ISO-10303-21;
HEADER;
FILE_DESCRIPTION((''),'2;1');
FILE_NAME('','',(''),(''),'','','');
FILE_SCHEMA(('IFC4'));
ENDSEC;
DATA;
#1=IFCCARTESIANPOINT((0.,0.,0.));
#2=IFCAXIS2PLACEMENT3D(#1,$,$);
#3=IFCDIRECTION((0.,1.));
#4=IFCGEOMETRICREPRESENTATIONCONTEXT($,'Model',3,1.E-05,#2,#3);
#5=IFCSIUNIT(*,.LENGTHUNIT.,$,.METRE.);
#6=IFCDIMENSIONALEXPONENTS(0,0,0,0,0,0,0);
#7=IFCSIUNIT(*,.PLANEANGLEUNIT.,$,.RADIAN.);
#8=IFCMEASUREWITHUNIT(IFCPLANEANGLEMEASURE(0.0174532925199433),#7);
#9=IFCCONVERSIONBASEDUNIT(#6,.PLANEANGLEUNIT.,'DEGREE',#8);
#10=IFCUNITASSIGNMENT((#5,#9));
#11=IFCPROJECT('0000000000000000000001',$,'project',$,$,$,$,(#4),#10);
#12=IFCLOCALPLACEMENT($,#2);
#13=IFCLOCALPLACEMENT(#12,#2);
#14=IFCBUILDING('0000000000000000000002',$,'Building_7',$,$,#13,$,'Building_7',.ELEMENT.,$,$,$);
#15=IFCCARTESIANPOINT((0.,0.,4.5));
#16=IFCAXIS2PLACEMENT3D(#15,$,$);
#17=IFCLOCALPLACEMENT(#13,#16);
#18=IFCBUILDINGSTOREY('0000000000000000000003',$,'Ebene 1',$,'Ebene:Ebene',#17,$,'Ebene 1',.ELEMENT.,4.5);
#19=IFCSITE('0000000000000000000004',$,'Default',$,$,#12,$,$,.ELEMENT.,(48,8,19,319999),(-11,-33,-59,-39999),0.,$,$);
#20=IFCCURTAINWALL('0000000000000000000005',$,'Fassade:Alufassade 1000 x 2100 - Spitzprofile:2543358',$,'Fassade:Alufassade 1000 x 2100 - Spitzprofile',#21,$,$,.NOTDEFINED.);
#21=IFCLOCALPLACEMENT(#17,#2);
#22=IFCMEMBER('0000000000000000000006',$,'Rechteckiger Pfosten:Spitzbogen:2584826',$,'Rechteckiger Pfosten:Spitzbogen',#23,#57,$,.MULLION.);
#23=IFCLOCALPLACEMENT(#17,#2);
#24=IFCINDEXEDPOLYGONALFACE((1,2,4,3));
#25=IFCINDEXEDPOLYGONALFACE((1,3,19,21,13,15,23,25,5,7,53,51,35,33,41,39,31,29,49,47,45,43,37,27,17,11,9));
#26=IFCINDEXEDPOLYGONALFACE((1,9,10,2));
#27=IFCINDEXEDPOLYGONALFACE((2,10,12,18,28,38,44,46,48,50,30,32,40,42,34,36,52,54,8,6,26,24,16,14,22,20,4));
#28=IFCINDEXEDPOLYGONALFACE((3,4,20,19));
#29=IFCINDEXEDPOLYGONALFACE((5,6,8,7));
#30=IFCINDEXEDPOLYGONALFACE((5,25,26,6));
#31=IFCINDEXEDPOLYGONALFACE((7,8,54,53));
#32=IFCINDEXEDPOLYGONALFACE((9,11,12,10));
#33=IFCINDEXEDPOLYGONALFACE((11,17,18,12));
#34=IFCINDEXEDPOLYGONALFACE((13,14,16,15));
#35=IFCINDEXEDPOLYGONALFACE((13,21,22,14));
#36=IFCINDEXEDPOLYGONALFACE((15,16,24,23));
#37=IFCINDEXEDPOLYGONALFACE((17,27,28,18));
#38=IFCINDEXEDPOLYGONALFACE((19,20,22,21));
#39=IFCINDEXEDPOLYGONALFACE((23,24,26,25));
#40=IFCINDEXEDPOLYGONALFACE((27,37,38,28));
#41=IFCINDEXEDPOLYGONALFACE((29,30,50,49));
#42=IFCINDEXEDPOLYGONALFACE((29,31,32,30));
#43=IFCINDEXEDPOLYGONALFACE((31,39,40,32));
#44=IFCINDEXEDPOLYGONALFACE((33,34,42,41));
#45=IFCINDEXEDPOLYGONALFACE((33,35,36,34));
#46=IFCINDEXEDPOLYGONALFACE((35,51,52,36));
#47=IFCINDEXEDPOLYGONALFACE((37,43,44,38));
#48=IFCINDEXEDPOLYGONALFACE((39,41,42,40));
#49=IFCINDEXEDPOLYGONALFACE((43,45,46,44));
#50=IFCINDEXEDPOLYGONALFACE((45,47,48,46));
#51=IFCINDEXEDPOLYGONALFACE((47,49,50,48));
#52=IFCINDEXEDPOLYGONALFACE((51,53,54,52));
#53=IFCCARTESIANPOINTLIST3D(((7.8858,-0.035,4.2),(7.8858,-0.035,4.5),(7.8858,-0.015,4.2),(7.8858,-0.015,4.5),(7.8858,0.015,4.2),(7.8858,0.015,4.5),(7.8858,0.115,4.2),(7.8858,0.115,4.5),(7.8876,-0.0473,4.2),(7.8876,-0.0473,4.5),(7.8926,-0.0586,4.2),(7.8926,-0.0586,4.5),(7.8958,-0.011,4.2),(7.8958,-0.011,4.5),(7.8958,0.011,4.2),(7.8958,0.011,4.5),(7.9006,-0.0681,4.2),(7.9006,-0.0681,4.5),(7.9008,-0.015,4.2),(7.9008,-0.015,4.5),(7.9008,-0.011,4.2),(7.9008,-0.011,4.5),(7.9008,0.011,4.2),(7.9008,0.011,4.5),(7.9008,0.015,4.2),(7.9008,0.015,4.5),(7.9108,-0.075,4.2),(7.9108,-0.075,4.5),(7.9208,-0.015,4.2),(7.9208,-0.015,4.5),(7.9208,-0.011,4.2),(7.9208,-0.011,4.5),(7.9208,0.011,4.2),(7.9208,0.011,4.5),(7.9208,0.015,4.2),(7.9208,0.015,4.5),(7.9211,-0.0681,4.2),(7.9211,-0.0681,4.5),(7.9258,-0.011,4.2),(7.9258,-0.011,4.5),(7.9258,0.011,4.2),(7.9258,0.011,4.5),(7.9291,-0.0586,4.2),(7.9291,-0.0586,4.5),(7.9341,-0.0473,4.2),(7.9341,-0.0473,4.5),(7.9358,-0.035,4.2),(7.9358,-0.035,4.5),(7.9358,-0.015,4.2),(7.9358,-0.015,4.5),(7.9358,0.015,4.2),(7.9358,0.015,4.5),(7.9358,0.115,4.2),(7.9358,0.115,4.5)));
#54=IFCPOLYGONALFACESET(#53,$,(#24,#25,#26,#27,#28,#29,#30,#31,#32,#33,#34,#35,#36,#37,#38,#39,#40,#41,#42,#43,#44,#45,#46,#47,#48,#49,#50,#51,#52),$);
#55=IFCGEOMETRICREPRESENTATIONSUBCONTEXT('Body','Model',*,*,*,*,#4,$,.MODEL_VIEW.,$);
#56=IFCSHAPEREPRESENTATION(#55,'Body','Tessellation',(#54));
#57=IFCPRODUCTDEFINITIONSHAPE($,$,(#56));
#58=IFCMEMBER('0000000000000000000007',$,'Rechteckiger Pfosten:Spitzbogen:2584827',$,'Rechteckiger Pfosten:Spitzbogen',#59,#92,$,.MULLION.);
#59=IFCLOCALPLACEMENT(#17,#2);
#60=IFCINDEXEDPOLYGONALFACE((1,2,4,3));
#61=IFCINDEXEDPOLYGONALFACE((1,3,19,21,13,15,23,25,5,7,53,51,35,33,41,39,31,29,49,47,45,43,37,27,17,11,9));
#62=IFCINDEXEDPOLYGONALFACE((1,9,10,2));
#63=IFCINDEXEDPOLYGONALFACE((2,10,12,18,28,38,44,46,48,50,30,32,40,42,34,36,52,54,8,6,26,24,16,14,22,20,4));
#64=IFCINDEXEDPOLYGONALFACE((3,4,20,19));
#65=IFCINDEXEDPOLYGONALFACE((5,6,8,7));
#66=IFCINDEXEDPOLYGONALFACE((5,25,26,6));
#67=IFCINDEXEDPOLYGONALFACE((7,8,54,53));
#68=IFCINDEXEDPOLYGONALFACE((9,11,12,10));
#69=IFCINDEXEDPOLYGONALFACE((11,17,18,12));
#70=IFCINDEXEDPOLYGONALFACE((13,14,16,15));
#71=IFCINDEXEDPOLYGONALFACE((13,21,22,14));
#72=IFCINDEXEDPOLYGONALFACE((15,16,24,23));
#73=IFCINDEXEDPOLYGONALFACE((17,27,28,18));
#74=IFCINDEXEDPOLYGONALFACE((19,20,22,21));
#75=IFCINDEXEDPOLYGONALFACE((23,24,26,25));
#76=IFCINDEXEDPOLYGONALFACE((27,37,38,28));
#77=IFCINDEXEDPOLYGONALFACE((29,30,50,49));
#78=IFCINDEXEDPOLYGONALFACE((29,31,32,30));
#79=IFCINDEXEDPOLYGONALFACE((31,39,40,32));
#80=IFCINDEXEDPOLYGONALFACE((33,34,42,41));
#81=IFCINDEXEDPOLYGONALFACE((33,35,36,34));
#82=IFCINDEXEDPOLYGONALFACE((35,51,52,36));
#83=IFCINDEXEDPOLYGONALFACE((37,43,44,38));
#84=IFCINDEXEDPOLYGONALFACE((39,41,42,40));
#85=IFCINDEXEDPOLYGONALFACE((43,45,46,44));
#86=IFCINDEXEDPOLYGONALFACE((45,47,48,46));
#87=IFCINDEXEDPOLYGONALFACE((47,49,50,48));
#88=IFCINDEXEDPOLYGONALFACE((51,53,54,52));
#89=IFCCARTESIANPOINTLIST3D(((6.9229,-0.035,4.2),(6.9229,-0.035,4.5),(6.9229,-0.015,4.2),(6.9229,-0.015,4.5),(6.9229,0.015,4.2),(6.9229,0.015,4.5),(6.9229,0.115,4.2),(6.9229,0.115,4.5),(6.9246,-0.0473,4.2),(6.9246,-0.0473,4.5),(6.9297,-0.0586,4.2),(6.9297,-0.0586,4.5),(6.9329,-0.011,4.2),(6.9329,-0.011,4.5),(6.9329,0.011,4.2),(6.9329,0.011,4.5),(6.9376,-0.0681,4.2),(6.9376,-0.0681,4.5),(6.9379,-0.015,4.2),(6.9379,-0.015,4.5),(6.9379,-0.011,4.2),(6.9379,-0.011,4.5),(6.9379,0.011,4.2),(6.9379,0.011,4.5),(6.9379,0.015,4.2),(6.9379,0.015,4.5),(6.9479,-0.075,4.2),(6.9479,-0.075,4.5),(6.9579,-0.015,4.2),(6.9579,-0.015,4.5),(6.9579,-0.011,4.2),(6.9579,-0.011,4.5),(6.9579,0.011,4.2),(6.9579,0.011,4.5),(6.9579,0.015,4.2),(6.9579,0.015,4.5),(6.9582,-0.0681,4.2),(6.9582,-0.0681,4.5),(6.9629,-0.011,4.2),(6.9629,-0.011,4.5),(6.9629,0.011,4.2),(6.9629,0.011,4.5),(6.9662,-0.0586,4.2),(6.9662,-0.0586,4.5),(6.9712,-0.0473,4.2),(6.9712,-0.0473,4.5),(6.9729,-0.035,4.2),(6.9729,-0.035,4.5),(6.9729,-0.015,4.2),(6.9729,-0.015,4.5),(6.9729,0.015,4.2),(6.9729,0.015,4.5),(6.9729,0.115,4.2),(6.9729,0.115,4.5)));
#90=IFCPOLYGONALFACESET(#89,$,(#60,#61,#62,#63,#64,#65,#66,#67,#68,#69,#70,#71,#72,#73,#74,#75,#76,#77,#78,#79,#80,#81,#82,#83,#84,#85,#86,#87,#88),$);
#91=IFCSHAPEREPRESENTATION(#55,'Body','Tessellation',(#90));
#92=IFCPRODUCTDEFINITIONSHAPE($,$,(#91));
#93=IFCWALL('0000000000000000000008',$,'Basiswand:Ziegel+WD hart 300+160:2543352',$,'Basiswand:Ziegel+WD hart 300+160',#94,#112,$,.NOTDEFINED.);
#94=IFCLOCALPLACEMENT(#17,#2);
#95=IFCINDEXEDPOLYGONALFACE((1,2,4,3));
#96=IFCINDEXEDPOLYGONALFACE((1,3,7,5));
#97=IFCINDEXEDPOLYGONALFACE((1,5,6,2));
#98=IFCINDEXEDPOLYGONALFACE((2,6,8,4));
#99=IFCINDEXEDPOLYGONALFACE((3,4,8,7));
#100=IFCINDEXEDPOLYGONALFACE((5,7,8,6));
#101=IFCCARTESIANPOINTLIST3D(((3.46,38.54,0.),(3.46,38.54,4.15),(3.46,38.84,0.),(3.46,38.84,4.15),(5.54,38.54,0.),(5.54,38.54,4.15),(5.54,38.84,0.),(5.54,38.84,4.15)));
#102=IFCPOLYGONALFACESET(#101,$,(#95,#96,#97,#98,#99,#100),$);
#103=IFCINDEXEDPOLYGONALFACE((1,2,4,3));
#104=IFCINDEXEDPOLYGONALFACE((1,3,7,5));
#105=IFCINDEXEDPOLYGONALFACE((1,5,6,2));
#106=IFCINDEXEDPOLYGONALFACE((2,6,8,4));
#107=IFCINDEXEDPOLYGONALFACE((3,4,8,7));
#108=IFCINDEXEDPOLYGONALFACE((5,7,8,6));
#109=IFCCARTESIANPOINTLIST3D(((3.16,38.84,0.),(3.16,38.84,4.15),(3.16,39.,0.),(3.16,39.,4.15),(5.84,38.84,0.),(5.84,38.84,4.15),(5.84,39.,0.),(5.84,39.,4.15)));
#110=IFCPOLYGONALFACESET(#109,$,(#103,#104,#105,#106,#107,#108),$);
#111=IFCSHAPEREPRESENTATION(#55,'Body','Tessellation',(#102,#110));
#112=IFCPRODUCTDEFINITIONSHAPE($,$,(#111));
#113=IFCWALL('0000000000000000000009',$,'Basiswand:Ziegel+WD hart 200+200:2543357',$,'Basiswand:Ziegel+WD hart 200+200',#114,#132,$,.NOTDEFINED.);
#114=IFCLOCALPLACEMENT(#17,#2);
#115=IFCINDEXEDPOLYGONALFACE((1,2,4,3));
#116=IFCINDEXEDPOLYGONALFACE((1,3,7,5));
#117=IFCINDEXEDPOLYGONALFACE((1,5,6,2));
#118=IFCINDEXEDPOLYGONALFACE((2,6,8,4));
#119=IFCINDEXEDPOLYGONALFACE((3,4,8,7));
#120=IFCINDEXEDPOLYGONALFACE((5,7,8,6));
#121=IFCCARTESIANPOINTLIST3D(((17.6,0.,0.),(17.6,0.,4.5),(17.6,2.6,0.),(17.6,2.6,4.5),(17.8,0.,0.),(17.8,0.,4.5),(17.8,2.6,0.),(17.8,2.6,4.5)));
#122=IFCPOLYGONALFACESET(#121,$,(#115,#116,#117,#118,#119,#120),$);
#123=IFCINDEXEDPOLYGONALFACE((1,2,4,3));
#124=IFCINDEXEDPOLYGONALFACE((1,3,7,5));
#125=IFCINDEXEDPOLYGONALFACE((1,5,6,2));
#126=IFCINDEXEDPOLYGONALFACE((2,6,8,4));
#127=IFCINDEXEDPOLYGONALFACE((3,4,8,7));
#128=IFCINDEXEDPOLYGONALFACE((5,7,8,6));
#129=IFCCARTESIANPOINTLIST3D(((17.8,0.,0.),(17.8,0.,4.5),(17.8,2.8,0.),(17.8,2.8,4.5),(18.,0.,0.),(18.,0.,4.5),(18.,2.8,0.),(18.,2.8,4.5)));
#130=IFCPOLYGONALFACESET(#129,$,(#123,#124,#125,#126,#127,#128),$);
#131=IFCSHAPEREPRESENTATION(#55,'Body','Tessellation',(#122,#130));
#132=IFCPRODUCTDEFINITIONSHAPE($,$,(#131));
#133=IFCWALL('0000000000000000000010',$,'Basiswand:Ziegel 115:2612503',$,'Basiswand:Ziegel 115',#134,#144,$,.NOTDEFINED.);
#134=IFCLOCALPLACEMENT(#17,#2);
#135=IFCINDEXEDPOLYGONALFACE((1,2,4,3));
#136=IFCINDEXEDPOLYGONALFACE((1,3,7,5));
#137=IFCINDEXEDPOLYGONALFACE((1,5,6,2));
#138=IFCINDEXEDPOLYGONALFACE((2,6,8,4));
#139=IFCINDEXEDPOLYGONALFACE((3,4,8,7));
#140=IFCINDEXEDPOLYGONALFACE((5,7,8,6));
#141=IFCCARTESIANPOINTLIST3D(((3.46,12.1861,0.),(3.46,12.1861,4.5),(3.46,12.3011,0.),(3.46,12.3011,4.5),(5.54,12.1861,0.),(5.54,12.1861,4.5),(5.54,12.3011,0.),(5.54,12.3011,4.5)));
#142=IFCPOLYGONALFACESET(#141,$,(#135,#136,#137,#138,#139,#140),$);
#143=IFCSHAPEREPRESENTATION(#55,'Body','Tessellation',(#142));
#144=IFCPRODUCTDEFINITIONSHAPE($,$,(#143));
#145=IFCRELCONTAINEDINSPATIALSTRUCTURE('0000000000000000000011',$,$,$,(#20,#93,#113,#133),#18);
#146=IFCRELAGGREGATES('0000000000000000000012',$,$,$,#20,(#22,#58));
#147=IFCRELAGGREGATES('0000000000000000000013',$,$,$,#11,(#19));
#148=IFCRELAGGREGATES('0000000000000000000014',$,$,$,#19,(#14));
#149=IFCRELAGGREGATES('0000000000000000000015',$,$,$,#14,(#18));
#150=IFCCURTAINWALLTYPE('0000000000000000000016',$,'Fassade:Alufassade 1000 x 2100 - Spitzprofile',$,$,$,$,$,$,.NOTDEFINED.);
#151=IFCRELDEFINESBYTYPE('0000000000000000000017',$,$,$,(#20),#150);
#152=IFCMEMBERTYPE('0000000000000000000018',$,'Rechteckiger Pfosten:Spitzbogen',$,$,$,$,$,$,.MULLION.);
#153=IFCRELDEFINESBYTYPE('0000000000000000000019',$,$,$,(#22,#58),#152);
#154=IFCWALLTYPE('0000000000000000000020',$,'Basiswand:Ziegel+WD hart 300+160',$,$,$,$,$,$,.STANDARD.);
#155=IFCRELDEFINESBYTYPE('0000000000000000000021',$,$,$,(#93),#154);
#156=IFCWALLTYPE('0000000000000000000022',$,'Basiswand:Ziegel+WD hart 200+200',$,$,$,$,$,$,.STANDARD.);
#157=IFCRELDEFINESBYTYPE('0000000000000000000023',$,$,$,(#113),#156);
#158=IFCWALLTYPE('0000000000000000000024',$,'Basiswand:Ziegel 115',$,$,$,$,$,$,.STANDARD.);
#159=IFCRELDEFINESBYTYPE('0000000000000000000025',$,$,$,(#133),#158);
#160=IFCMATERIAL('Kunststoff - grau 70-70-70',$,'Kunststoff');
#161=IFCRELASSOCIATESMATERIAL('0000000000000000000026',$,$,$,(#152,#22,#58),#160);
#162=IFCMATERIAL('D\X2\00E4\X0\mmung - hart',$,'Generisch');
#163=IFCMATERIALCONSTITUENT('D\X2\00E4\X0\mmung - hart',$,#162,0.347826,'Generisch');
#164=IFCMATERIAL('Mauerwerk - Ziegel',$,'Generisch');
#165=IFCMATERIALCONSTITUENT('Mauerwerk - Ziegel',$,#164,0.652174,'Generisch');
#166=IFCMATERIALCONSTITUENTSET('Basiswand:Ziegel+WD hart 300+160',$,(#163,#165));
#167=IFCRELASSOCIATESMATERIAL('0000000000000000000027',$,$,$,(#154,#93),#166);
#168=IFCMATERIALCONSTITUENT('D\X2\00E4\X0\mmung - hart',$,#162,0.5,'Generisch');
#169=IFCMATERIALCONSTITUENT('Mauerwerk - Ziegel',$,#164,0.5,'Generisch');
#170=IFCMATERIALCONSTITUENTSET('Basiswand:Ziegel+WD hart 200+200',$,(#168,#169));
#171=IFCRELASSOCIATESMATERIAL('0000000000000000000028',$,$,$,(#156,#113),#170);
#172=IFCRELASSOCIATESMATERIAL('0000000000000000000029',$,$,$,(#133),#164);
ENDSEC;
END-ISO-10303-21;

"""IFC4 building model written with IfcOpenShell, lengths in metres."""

from ifc_helpers import new_model, entity, si_unit, converted_unit, direction, frame, origin, place, context, subcontext, project, spatial, line, arc, indexed_curve, outline, extrude, source, transform, mapped, material, constituent, constituent_set, type_object, type_shapes, element, aggregate, save


model = new_model("IFC4")

# Units and contexts
model_context = context("Model", 3, precision=1e-05, world=origin(), true_north=direction((0.0, 1.0)))
body_context = subcontext(model_context, "Body", "Model", "MODEL_VIEW")
ifc_project = project(units=[si_unit("LENGTHUNIT", "METRE"), converted_unit("PLANEANGLEUNIT", "DEGREE", entity("IfcPlaneAngleMeasure", 0.0174532925199433), si_unit("PLANEANGLEUNIT", "RADIAN"), dimensions=[0, 0, 0, 0, 0, 0, 0])], contexts=[model_context])

# Site, building, storey
site_placement = place(None, origin())
site = spatial("IfcSite", under=ifc_project, at=site_placement, Name="Default", CompositionType="ELEMENT", RefLatitude=(48, 8, 19, 319999), RefLongitude=(-11, -33, -59, -39999), RefElevation=0.0)
building_placement = place(site_placement, origin())
building = spatial("IfcBuilding", under=site, at=building_placement, Name="Building_7", LongName="Building_7", CompositionType="ELEMENT")
storey_placement = place(building_placement, frame((0.0, 0.0, 4.5)))
storey = spatial("IfcBuildingStorey", under=building, at=storey_placement, Name="Ebene 1", ObjectType="Ebene:Ebene", LongName="Ebene 1", CompositionType="ELEMENT", Elevation=4.5)

# Curtain wall, members
curtain_wall_type = type_object("IfcCurtainWallType", Name="Fassade:Alufassade 1000 x 2100 - Spitzprofile", PredefinedType="NOTDEFINED")
curtain_wall_placement = place(storey_placement, frame((0.0, 0.0, -4.5)))
curtain_wall = element("IfcCurtainWall", 1, at=curtain_wall_placement, inside=storey, type_object=curtain_wall_type, Name="Fassade:Alufassade 1000 x 2100 - Spitzprofile:2543358", ObjectType="Fassade:Alufassade 1000 x 2100 - Spitzprofile", PredefinedType="NOTDEFINED")
ifc_material_1 = material(Name="Kunststoff - grau 70-70-70", Category="Kunststoff")
member_type_1 = type_object("IfcMemberType", Name="Rechteckiger Pfosten:Spitzbogen", PredefinedType="MULLION", material=ifc_material_1)
shared_shape_1 = source(origin(), body_context, "Body", "SweptSolid", [
    extrude(outline(indexed_curve([(-0.111, -0.025), (-0.011, -0.025), (-0.011, -0.01), (-0.007, -0.01), (-0.007, -0.015), (0.015, -0.015), (0.015, -0.01), (0.019, -0.01), (0.019, -0.025), (0.039, -0.025), (0.0626, -0.0182), (0.079, 0.0), (0.0626, 0.0182), (0.039, 0.025), (0.019, 0.025), (0.019, 0.01), (0.015, 0.01), (0.015, 0.015), (-0.007, 0.015), (-0.007, 0.01), (-0.011, 0.01), (-0.011, 0.025), (-0.111, 0.025)], segments=[line(1, 2, 3, 4, 5, 6, 7, 8, 9, 10), arc(10, 11, 12), arc(12, 13, 14), line(14, 15, 16, 17, 18, 19, 20, 21, 22, 23, 1)], self_intersect=False)), frame((0.0, 0.004, -0.3), z_axis=(0.0, 0.0, 1.0), x_axis=(0.0, -1.0, 0.0)), (0.0, 0.0, 1.0), 0.3),
])
type_shapes(member_type_1, [shared_shape_1])
member_1_placement = place(curtain_wall_placement, frame((7.9108, 0.0, 8.7), z_axis=(0.0, 0.0, -1.0), x_axis=(-1.0, 0.0, 0.0)))
member_1 = element("IfcMember", 2, at=member_1_placement, type_object=member_type_1, material=ifc_material_1, Name="Rechteckiger Pfosten:Spitzbogen:2584826", ObjectType="Rechteckiger Pfosten:Spitzbogen", PredefinedType="MULLION", context=body_context, shape_type="MappedRepresentation", body=[
    mapped(shared_shape_1, transform((0.0, 0.0, 0.0), scale=1.0)),
])
member_2_placement = place(curtain_wall_placement, frame((6.9479, 0.0, 8.7), z_axis=(0.0, 0.0, -1.0), x_axis=(-1.0, 0.0, 0.0)))
member_2 = element("IfcMember", 3, at=member_2_placement, type_object=member_type_1, material=ifc_material_1, Name="Rechteckiger Pfosten:Spitzbogen:2584827", ObjectType="Rechteckiger Pfosten:Spitzbogen", PredefinedType="MULLION", context=body_context, shape_type="MappedRepresentation", body=[
    mapped(shared_shape_1, transform((0.0, 0.0, 0.0), scale=1.0)),
])
aggregate(curtain_wall, [member_1, member_2])

# Wall
ifc_material_2 = material(Name="Dämmung - hart", Category="Generisch")
ifc_constituent_1 = constituent(ifc_material_2, Name="Dämmung - hart", Category="Generisch", fraction=0.347826)
ifc_material_3 = material(Name="Mauerwerk - Ziegel", Category="Generisch")
ifc_constituent_2 = constituent(ifc_material_3, Name="Mauerwerk - Ziegel", Category="Generisch", fraction=0.652174)
ifc_constituent_set_1 = constituent_set(constituents=[ifc_constituent_1, ifc_constituent_2], Name="Basiswand:Ziegel+WD hart 300+160")
wall_type_1 = type_object("IfcWallType", Name="Basiswand:Ziegel+WD hart 300+160", PredefinedType="STANDARD", material=ifc_constituent_set_1)
wall_1_placement = place(storey_placement, frame((3.46, 38.77, 0.0)))
element("IfcWall", 4, at=wall_1_placement, inside=storey, type_object=wall_type_1, material=ifc_constituent_set_1, Name="Basiswand:Ziegel+WD hart 300+160:2543352", ObjectType="Basiswand:Ziegel+WD hart 300+160", PredefinedType="NOTDEFINED", context=body_context, shape_type="SweptSolid", body=[
    extrude(outline(indexed_curve([(-0.15, -1.04), (0.15, -1.04), (0.15, 1.04), (-0.15, 1.04), (-0.15, -1.04)], self_intersect=False)), frame((1.04, -0.08, 0.0), z_axis=(0.0, 0.0, 1.0), x_axis=(0.0, 1.0, 0.0)), (0.0, 0.0, 1.0), 4.15),
    extrude(outline(indexed_curve([(-0.08, -1.34), (0.08, -1.34), (0.08, 1.34), (-0.08, 1.34), (-0.08, -1.34)], self_intersect=False)), frame((1.04, 0.15, 0.0), z_axis=(0.0, 0.0, 1.0), x_axis=(0.0, -1.0, 0.0)), (0.0, 0.0, 1.0), 4.15),
])

# Shared definitions
ifc_constituent_3 = constituent(ifc_material_2, Name="Dämmung - hart", Category="Generisch", fraction=0.5)
ifc_constituent_4 = constituent(ifc_material_3, Name="Mauerwerk - Ziegel", Category="Generisch", fraction=0.5)
ifc_constituent_set_2 = constituent_set(constituents=[ifc_constituent_3, ifc_constituent_4], Name="Basiswand:Ziegel+WD hart 200+200")
wall_type_2 = type_object("IfcWallType", Name="Basiswand:Ziegel+WD hart 200+200", PredefinedType="STANDARD", material=ifc_constituent_set_2)

# Walls
wall_2_placement = place(storey_placement, frame((17.8, 2.6, 0.0), z_axis=(0.0, 0.0, 1.0), x_axis=(0.0, -1.0, 0.0)))
element("IfcWall", 5, at=wall_2_placement, inside=storey, type_object=wall_type_2, material=ifc_constituent_set_2, Name="Basiswand:Ziegel+WD hart 200+200:2543357", ObjectType="Basiswand:Ziegel+WD hart 200+200", PredefinedType="NOTDEFINED", context=body_context, shape_type="SweptSolid", body=[
    extrude(outline(indexed_curve([(-0.1, -1.3), (0.1, -1.3), (0.1, 1.3), (-0.1, 1.3), (-0.1, -1.3)], self_intersect=False)), frame((1.3, -0.1, 0.0), z_axis=(0.0, 0.0, 1.0), x_axis=(0.0, 1.0, 0.0)), (0.0, 0.0, 1.0), 4.5),
    extrude(outline(indexed_curve([(-0.1, -1.4), (0.1, -1.4), (0.1, 1.4), (-0.1, 1.4), (-0.1, -1.4)], self_intersect=False)), frame((1.2, 0.1, 0.0), z_axis=(0.0, 0.0, 1.0), x_axis=(0.0, -1.0, 0.0)), (0.0, 0.0, 1.0), 4.5),
])
wall_type_3 = type_object("IfcWallType", Name="Basiswand:Ziegel 115", PredefinedType="STANDARD")
wall_3_placement = place(storey_placement, frame((3.46, 12.2436, 0.0)))
element("IfcWall", 6, at=wall_3_placement, inside=storey, type_object=wall_type_3, material=ifc_material_3, Name="Basiswand:Ziegel 115:2612503", ObjectType="Basiswand:Ziegel 115", PredefinedType="NOTDEFINED", context=body_context, shape_type="SweptSolid", body=[
    extrude(outline(indexed_curve([(2.08, 0.0575), (0.0, 0.0575), (0.0, -0.0575), (2.08, -0.0575), (2.08, 0.0575)], self_intersect=False)), origin(), (0.0, 0.0, 1.0), 4.5),
])

save(model, "model.ifc")
